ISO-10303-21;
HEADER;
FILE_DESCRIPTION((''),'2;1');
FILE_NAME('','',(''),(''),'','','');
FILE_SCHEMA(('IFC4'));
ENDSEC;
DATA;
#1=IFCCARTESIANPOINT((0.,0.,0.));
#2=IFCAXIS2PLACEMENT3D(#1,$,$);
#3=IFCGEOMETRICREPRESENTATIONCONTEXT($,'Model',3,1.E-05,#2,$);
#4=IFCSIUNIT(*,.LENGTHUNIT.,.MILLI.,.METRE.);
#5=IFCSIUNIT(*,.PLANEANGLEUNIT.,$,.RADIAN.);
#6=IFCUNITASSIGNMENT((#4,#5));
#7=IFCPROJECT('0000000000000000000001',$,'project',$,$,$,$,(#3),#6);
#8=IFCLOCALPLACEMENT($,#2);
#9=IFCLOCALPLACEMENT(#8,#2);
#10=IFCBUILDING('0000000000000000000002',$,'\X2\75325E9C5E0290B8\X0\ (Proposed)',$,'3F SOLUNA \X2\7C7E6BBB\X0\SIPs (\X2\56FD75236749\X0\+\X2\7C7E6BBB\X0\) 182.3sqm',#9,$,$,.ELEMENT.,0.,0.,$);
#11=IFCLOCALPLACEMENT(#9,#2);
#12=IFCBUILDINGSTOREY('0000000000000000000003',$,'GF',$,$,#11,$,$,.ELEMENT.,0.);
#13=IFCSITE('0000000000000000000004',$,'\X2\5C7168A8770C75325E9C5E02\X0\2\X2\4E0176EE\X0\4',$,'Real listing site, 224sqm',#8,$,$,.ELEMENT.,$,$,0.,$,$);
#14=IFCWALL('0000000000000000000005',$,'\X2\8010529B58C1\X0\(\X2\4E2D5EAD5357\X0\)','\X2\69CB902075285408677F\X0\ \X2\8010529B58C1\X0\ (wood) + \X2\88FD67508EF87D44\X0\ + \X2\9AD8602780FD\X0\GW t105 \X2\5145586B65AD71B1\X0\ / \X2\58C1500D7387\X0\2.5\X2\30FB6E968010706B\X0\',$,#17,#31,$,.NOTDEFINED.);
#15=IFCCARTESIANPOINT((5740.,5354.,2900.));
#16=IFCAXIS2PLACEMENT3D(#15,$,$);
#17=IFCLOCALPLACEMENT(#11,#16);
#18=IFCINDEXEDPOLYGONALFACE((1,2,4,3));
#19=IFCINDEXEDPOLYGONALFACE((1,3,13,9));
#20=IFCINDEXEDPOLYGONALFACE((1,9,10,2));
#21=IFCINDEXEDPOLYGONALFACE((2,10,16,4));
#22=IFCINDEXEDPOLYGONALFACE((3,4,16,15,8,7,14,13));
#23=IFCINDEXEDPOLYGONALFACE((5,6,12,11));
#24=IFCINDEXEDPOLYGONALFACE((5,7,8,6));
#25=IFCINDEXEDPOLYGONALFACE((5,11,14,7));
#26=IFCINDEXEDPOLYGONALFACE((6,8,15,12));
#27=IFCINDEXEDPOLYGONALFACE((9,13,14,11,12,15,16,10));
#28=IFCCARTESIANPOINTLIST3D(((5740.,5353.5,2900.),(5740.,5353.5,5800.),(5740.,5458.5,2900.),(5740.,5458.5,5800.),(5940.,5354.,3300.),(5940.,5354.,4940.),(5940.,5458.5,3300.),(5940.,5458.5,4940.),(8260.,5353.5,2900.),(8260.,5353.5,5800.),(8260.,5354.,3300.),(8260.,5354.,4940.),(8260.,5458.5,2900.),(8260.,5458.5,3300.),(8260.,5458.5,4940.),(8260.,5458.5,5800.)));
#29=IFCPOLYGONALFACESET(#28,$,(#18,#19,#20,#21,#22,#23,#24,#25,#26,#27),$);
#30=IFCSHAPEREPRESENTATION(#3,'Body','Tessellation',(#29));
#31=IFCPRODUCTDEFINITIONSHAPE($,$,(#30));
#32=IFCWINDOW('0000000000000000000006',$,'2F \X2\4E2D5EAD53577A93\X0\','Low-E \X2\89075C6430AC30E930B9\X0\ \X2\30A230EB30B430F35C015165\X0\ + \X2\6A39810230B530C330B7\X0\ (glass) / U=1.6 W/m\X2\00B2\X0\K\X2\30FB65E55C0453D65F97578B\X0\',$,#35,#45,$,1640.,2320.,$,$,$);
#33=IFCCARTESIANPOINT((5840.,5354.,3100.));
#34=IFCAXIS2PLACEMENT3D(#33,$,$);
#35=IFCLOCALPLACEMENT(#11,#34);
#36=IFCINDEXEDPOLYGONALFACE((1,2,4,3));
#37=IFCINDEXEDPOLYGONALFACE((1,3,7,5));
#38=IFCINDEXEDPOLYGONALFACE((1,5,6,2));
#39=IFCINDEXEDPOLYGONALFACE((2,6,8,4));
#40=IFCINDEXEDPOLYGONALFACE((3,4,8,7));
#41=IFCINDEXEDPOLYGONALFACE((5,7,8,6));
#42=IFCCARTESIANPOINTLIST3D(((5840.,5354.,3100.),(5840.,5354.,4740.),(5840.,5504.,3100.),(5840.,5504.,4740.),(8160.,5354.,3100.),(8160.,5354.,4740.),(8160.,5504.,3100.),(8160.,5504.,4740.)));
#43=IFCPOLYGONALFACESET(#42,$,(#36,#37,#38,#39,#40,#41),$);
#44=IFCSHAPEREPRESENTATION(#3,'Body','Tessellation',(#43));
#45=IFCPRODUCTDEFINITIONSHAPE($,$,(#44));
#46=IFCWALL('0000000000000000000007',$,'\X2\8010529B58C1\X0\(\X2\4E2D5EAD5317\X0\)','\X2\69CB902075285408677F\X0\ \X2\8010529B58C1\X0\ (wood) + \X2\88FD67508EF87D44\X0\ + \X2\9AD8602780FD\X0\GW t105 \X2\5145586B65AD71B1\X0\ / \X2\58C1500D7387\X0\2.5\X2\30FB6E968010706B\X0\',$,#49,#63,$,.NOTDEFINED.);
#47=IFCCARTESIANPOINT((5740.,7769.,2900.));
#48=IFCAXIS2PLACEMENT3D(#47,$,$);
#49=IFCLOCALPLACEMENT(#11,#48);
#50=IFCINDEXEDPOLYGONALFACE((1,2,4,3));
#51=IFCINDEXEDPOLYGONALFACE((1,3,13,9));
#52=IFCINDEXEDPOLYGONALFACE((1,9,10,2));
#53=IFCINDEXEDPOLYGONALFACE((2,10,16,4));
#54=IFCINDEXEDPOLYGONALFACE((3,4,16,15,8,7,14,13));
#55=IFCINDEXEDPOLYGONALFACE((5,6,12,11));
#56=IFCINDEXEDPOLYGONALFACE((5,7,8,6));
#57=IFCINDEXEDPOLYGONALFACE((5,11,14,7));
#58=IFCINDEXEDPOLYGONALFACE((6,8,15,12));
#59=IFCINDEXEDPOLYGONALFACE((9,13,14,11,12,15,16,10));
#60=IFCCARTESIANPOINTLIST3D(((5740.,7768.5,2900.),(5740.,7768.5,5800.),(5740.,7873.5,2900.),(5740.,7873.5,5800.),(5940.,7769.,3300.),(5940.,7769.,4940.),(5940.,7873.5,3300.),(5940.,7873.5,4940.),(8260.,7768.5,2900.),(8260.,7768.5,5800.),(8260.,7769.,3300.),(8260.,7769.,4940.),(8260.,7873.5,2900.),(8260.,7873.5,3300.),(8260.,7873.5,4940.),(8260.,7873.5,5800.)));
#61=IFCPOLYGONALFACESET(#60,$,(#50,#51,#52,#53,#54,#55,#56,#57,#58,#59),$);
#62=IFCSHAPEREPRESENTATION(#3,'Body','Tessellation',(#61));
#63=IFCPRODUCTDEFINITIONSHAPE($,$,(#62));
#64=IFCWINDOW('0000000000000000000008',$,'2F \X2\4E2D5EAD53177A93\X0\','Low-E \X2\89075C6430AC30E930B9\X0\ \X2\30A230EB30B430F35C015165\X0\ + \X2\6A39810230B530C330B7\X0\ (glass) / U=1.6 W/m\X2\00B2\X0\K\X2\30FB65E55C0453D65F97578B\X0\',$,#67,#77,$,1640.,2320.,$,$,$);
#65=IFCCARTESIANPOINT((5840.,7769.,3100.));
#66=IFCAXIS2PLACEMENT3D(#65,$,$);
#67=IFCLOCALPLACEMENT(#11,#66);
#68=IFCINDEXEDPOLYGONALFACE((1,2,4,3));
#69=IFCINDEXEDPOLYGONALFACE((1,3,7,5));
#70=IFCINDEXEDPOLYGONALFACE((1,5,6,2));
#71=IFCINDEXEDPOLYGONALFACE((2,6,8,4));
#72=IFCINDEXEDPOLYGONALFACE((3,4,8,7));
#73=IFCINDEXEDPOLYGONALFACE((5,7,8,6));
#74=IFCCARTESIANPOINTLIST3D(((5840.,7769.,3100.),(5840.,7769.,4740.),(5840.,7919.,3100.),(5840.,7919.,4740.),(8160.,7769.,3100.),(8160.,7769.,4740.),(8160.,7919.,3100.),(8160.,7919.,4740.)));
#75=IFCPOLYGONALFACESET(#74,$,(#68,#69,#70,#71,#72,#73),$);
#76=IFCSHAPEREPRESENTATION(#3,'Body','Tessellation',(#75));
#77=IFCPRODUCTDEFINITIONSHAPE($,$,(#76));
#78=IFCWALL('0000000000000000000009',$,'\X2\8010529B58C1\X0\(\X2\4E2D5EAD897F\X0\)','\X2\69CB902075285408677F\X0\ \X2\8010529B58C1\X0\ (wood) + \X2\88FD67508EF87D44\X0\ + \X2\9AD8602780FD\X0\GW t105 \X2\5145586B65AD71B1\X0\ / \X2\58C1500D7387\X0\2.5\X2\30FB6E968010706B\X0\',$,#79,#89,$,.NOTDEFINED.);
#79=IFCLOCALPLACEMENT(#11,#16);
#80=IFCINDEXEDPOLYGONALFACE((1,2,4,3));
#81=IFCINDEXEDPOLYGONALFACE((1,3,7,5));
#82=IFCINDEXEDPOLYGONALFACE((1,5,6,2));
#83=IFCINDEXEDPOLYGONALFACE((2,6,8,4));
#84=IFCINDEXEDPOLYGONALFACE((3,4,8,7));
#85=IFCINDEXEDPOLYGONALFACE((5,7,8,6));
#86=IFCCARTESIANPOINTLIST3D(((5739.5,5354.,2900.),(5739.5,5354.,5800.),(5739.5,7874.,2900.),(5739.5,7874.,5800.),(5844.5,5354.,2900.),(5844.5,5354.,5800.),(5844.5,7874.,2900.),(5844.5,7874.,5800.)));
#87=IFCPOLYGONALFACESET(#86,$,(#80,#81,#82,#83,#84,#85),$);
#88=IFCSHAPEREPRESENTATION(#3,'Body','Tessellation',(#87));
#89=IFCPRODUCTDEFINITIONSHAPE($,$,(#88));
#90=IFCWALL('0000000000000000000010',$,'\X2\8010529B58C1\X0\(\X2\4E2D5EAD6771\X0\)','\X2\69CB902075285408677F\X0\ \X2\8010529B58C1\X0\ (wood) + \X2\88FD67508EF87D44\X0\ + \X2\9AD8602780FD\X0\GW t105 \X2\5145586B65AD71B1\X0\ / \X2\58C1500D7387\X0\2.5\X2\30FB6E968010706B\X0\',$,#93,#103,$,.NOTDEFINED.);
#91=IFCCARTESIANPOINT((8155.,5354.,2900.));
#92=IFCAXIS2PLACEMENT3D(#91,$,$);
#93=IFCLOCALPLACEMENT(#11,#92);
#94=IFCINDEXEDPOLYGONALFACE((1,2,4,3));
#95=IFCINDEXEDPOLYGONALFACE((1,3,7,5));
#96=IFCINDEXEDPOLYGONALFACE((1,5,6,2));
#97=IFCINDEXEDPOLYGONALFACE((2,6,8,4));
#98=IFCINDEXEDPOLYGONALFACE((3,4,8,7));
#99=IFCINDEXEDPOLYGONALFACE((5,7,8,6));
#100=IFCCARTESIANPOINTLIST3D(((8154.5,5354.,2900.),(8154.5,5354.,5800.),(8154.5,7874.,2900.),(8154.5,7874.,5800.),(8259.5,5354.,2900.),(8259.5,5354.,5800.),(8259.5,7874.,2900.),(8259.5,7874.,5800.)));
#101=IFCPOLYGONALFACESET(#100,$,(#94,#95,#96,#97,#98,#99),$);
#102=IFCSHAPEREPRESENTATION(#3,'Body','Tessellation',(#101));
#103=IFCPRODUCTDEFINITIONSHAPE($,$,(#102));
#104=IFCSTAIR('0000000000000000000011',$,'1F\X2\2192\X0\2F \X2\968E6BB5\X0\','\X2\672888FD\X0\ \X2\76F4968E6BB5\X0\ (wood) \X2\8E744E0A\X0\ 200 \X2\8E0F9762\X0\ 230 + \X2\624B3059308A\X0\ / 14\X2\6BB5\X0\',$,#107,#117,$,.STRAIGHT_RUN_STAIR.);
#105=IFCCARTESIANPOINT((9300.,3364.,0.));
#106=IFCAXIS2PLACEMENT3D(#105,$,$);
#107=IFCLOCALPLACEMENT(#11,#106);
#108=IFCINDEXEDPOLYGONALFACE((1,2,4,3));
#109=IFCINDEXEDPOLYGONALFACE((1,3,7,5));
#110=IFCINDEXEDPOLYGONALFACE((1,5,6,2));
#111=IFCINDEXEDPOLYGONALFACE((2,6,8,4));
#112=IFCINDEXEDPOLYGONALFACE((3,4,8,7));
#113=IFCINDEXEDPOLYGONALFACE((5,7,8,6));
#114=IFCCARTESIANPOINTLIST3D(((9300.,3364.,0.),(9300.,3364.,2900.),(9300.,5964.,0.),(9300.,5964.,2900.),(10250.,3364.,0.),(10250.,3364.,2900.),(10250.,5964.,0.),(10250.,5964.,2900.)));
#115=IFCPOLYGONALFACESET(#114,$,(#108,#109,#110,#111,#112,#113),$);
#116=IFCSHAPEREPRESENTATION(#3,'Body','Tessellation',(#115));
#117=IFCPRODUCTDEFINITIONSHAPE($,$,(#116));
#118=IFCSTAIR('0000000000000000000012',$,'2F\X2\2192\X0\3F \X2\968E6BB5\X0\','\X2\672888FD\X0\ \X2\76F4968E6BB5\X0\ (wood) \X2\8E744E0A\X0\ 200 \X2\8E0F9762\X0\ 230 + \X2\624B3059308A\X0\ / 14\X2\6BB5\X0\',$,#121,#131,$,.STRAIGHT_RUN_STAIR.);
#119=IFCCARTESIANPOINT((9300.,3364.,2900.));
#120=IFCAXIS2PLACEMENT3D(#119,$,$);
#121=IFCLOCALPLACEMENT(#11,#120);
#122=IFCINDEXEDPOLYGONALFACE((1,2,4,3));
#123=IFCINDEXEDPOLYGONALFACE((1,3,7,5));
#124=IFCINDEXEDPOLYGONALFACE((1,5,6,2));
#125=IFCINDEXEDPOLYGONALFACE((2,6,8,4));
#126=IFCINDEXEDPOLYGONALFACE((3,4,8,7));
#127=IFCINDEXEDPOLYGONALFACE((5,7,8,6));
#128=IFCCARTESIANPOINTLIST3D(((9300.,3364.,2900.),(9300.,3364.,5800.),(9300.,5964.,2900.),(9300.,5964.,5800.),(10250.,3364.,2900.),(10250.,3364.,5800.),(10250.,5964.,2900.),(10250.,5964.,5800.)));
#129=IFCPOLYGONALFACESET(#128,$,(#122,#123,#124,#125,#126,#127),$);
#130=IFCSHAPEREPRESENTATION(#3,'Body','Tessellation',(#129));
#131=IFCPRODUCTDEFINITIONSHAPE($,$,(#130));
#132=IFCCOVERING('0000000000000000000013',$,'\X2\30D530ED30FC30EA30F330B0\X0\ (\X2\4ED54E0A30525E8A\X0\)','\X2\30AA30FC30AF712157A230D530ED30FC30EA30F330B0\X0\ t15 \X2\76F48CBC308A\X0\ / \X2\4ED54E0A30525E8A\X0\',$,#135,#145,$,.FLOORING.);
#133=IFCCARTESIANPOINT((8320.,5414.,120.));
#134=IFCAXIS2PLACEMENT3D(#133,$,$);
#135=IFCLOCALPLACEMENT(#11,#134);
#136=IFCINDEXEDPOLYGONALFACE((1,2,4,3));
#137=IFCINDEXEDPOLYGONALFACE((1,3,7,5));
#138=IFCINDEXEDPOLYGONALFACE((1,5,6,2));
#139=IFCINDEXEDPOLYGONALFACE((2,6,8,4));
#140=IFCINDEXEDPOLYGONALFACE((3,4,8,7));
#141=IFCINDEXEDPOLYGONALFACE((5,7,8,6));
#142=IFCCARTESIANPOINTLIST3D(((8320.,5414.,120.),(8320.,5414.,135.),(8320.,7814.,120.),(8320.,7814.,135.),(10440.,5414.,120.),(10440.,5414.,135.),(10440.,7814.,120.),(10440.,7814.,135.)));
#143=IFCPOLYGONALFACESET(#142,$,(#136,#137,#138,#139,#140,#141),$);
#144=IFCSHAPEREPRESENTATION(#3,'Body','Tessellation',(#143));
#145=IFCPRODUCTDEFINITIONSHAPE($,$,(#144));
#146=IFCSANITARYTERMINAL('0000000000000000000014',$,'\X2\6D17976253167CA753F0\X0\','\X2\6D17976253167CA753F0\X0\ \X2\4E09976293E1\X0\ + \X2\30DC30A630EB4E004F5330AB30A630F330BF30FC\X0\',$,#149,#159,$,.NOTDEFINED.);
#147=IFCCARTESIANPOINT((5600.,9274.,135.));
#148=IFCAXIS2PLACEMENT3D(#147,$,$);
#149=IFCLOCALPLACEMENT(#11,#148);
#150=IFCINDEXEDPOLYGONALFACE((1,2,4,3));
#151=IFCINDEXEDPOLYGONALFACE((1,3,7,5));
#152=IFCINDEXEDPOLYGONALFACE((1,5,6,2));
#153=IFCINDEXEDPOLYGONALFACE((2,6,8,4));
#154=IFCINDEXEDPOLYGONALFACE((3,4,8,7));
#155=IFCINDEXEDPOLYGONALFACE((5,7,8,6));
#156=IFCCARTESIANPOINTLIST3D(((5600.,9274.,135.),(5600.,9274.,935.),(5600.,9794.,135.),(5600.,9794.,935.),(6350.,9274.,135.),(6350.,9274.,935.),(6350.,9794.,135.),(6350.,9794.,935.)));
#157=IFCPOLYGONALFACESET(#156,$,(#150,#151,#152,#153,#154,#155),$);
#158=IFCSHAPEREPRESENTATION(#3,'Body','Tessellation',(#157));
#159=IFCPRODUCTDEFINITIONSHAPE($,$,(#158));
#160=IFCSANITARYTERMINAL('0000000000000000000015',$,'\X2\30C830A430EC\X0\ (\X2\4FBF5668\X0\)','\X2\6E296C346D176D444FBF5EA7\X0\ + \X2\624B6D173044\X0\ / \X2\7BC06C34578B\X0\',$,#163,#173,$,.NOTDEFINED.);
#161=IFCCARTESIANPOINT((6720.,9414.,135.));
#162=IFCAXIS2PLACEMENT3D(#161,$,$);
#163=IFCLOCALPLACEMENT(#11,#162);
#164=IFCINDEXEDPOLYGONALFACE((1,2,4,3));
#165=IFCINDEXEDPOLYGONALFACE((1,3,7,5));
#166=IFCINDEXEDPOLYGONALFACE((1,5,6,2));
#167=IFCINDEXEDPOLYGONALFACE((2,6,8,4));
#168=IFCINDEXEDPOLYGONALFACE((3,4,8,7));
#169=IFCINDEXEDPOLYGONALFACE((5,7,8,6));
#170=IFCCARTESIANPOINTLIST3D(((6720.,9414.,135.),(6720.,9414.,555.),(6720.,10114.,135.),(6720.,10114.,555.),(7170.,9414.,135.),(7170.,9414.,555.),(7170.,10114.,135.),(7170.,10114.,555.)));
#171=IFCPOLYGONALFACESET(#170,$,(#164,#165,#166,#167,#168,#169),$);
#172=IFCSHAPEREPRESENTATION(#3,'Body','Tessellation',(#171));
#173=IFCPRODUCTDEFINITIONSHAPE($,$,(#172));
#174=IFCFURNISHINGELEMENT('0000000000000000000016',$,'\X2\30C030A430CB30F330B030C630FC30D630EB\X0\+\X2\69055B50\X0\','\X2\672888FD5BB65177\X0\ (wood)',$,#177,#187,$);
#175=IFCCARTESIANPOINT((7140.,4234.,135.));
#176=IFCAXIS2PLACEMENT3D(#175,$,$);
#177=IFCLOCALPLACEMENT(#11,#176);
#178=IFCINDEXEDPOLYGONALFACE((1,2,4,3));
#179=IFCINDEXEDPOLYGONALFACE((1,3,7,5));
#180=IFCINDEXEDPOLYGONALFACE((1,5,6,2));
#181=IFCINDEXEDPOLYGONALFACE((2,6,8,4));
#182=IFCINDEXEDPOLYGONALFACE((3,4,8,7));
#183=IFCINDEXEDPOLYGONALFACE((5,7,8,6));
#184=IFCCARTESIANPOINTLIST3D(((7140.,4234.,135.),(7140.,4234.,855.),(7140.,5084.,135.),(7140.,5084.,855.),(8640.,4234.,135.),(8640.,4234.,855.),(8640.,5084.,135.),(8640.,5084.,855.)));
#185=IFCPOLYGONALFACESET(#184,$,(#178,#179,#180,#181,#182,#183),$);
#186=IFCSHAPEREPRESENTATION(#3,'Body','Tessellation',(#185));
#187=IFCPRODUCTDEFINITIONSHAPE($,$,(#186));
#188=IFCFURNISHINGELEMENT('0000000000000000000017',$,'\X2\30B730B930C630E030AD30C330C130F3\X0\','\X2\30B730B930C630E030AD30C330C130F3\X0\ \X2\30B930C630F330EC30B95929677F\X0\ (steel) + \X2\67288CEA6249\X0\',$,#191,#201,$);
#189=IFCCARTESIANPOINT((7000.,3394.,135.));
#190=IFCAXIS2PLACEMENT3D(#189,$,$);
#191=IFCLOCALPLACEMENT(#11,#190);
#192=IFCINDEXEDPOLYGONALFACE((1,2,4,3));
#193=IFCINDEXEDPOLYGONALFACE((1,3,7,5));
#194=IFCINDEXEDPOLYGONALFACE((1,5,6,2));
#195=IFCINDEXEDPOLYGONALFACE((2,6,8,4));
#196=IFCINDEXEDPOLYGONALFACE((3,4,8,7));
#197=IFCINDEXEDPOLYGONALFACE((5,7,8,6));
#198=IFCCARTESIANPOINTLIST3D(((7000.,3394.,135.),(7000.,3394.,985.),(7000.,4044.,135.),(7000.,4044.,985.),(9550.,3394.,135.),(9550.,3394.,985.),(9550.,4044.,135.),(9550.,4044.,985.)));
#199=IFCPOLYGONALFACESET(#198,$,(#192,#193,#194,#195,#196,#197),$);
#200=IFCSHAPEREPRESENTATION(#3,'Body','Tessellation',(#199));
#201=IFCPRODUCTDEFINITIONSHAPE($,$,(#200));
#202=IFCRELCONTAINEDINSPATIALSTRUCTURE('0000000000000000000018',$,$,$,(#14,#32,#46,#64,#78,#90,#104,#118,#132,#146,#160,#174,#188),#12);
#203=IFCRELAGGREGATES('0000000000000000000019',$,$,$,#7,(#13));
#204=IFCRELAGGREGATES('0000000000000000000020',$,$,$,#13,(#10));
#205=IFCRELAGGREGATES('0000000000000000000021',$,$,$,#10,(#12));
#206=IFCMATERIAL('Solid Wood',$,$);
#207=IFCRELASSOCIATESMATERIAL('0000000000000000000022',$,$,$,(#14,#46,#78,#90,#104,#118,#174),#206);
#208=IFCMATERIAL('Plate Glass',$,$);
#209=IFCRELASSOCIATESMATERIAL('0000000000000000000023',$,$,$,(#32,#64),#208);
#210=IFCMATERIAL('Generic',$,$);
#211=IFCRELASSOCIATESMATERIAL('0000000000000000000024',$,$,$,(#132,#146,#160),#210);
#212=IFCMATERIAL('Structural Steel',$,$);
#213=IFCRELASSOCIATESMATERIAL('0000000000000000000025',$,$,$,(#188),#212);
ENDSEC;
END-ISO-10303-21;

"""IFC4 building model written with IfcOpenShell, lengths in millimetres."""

from ifc_helpers import new_model, si_unit, frame, frame_2d, origin, place, context, project, spatial, rectangle, extrude, material, element, fill, save


model = new_model("IFC4")

# Units and contexts
model_context = context("Model", 3, precision=1e-05, world=origin())
ifc_project = project(units=[si_unit("LENGTHUNIT", "METRE", prefix="MILLI"), si_unit("PLANEANGLEUNIT", "RADIAN")], contexts=[model_context])

# Site, building, storey
site_placement = place(None, origin())
site = spatial("IfcSite", under=ifc_project, at=site_placement, Name="山梨県甲府市2丁目4", ObjectType="Real listing site, 224sqm", CompositionType="ELEMENT", RefElevation=0.0)
building_placement = place(site_placement, origin())
building = spatial("IfcBuilding", under=site, at=building_placement, Name="甲府市邸 (Proposed)", ObjectType="3F SOLUNA 籾殻SIPs (国産杉+籾殻) 182.3sqm", CompositionType="ELEMENT", ElevationOfRefHeight=0.0, ElevationOfTerrain=0.0)
storey_placement = place(building_placement, origin())
storey = spatial("IfcBuildingStorey", under=building, at=storey_placement, Name="GF", CompositionType="ELEMENT", Elevation=0.0)

# Shared definitions
ifc_material_1 = material(Name="Solid Wood")

# Shared definitions
ifc_material_2 = material(Name="Plate Glass")

# Walls, openings, windows
wall_1_placement = place(storey_placement, frame((5740.0, 5354.0, 2900.0)))
wall_1 = element("IfcWall", 1, at=wall_1_placement, inside=storey, material=ifc_material_1, Name="耐力壁(中庭南)", Description="構造用合板 耐力壁 (wood) + 製材軸組 + 高性能GW t105 充填断熱 / 壁倍率2.5・準耐火", PredefinedType="NOTDEFINED", context=model_context, shape_type="SweptSolid", body=[
    extrude(rectangle(XDim=2520.0, YDim=105.0, at=frame_2d((1260.0, 52.0))), frame((5740.0, 5354.0, 2900.0)), (0.0, 0.0, 1.0), 2900.0),
])
opening_1_placement = place(storey_placement, frame((5840.0, 5354.0, 3100.0)))
opening_1 = element("IfcOpeningElement", 2, at=opening_1_placement, cuts=wall_1, PredefinedType="NOTDEFINED", context=model_context, shape_type="SweptSolid", body=[
    extrude(rectangle(XDim=2320.0, YDim=150.0, at=frame_2d((1160.0, 75.0))), frame((5840.0, 5354.0, 3100.0)), (0.0, 0.0, 1.0), 1640.0),
])
window_1_placement = place(storey_placement, frame((5840.0, 5354.0, 3100.0)))
window_1 = element("IfcWindow", 3, at=window_1_placement, inside=storey, material=ifc_material_2, Name="2F 中庭南窓", Description="Low-E 複層ガラス アルゴン封入 + 樹脂サッシ (glass) / U=1.6 W/m²K・日射取得型", OverallHeight=1640.0, OverallWidth=2320.0, context=model_context, shape_type="SweptSolid", body=[
    extrude(rectangle(XDim=2320.0, YDim=150.0, at=frame_2d((1160.0, 75.0))), frame((5840.0, 5354.0, 3100.0)), (0.0, 0.0, 1.0), 1640.0),
])
fill(opening_1, window_1)
wall_2_placement = place(storey_placement, frame((5740.0, 7769.0, 2900.0)))
wall_2 = element("IfcWall", 4, at=wall_2_placement, inside=storey, material=ifc_material_1, Name="耐力壁(中庭北)", Description="構造用合板 耐力壁 (wood) + 製材軸組 + 高性能GW t105 充填断熱 / 壁倍率2.5・準耐火", PredefinedType="NOTDEFINED", context=model_context, shape_type="SweptSolid", body=[
    extrude(rectangle(XDim=2520.0, YDim=105.0, at=frame_2d((1260.0, 52.0))), frame((5740.0, 7769.0, 2900.0)), (0.0, 0.0, 1.0), 2900.0),
])
opening_2_placement = place(storey_placement, frame((5840.0, 7769.0, 3100.0)))
opening_2 = element("IfcOpeningElement", 5, at=opening_2_placement, cuts=wall_2, PredefinedType="NOTDEFINED", context=model_context, shape_type="SweptSolid", body=[
    extrude(rectangle(XDim=2320.0, YDim=150.0, at=frame_2d((1160.0, 75.0))), frame((5840.0, 7769.0, 3100.0)), (0.0, 0.0, 1.0), 1640.0),
])
window_2_placement = place(storey_placement, frame((5840.0, 7769.0, 3100.0)))
window_2 = element("IfcWindow", 6, at=window_2_placement, inside=storey, material=ifc_material_2, Name="2F 中庭北窓", Description="Low-E 複層ガラス アルゴン封入 + 樹脂サッシ (glass) / U=1.6 W/m²K・日射取得型", OverallHeight=1640.0, OverallWidth=2320.0, context=model_context, shape_type="SweptSolid", body=[
    extrude(rectangle(XDim=2320.0, YDim=150.0, at=frame_2d((1160.0, 75.0))), frame((5840.0, 7769.0, 3100.0)), (0.0, 0.0, 1.0), 1640.0),
])
fill(opening_2, window_2)

# Walls
wall_3_placement = place(storey_placement, frame((5740.0, 5354.0, 2900.0)))
element("IfcWall", 7, at=wall_3_placement, inside=storey, material=ifc_material_1, Name="耐力壁(中庭西)", Description="構造用合板 耐力壁 (wood) + 製材軸組 + 高性能GW t105 充填断熱 / 壁倍率2.5・準耐火", PredefinedType="NOTDEFINED", context=model_context, shape_type="SweptSolid", body=[
    extrude(rectangle(XDim=105.0, YDim=2520.0, at=frame_2d((52.0, 1260.0))), frame((5740.0, 5354.0, 2900.0)), (0.0, 0.0, 1.0), 2900.0),
])
wall_4_placement = place(storey_placement, frame((8155.0, 5354.0, 2900.0)))
element("IfcWall", 8, at=wall_4_placement, inside=storey, material=ifc_material_1, Name="耐力壁(中庭東)", Description="構造用合板 耐力壁 (wood) + 製材軸組 + 高性能GW t105 充填断熱 / 壁倍率2.5・準耐火", PredefinedType="NOTDEFINED", context=model_context, shape_type="SweptSolid", body=[
    extrude(rectangle(XDim=105.0, YDim=2520.0, at=frame_2d((52.0, 1260.0))), frame((8155.0, 5354.0, 2900.0)), (0.0, 0.0, 1.0), 2900.0),
])

# Stairs
stair_1_placement = place(storey_placement, frame((9300.0, 3364.0, 0.0)))
element("IfcStair", 9, at=stair_1_placement, inside=storey, material=ifc_material_1, Name="1F→2F 階段", Description="木製 直階段 (wood) 蹴上 200 踏面 230 + 手すり / 14段", PredefinedType="STRAIGHT_RUN_STAIR", context=model_context, shape_type="SweptSolid", body=[
    extrude(rectangle(XDim=950.0, YDim=2600.0, at=frame_2d((475.0, 1300.0))), frame((9300.0, 3364.0, 0.0)), (0.0, 0.0, 1.0), 2900.0),
])
stair_2_placement = place(storey_placement, frame((9300.0, 3364.0, 2900.0)))
element("IfcStair", 10, at=stair_2_placement, inside=storey, material=ifc_material_1, Name="2F→3F 階段", Description="木製 直階段 (wood) 蹴上 200 踏面 230 + 手すり / 14段", PredefinedType="STRAIGHT_RUN_STAIR", context=model_context, shape_type="SweptSolid", body=[
    extrude(rectangle(XDim=950.0, YDim=2600.0, at=frame_2d((475.0, 1300.0))), frame((9300.0, 3364.0, 2900.0)), (0.0, 0.0, 1.0), 2900.0),
])

# Covering
ifc_material_3 = material(Name="Generic")
covering_placement = place(storey_placement, frame((8320.0, 5414.0, 120.0)))
element("IfcCovering", 11, at=covering_placement, inside=storey, material=ifc_material_3, Name="フローリング (仕上げ床)", Description="オーク無垢フローリング t15 直貼り / 仕上げ床", PredefinedType="FLOORING", context=model_context, shape_type="SweptSolid", body=[
    extrude(rectangle(XDim=2120.0, YDim=2400.0, at=frame_2d((1060.0, 1200.0))), frame((8320.0, 5414.0, 120.0)), (0.0, 0.0, 1.0), 15.0),
])

# Sanitary terminals
sanitary_terminal_1_placement = place(storey_placement, frame((5600.0, 9274.0, 135.0)))
element("IfcSanitaryTerminal", 12, at=sanitary_terminal_1_placement, inside=storey, material=ifc_material_3, Name="洗面化粧台", Description="洗面化粧台 三面鏡 + ボウル一体カウンター", PredefinedType="NOTDEFINED", context=model_context, shape_type="SweptSolid", body=[
    extrude(rectangle(XDim=750.0, YDim=520.0, at=frame_2d((375.0, 260.0))), frame((5600.0, 9274.0, 135.0)), (0.0, 0.0, 1.0), 800.0),
])
sanitary_terminal_2_placement = place(storey_placement, frame((6720.0, 9414.0, 135.0)))
element("IfcSanitaryTerminal", 13, at=sanitary_terminal_2_placement, inside=storey, material=ifc_material_3, Name="トイレ (便器)", Description="温水洗浄便座 + 手洗い / 節水型", PredefinedType="NOTDEFINED", context=model_context, shape_type="SweptSolid", body=[
    extrude(rectangle(XDim=450.0, YDim=700.0, at=frame_2d((225.0, 350.0))), frame((6720.0, 9414.0, 135.0)), (0.0, 0.0, 1.0), 420.0),
])

# Furnishing elements
furnishing_1_placement = place(storey_placement, frame((7140.0, 4234.0, 135.0)))
element("IfcFurnishingElement", 14, at=furnishing_1_placement, inside=storey, material=ifc_material_1, Name="ダイニングテーブル+椅子", Description="木製家具 (wood)", context=model_context, shape_type="SweptSolid", body=[
    extrude(rectangle(XDim=1500.0, YDim=850.0, at=frame_2d((750.0, 425.0))), frame((7140.0, 4234.0, 135.0)), (0.0, 0.0, 1.0), 720.0),
])
ifc_material_4 = material(Name="Structural Steel")
furnishing_2_placement = place(storey_placement, frame((7000.0, 3394.0, 135.0)))
element("IfcFurnishingElement", 15, at=furnishing_2_placement, inside=storey, material=ifc_material_4, Name="システムキッチン", Description="システムキッチン ステンレス天板 (steel) + 木質扉", context=model_context, shape_type="SweptSolid", body=[
    extrude(rectangle(XDim=2550.0, YDim=650.0, at=frame_2d((1275.0, 325.0))), frame((7000.0, 3394.0, 135.0)), (0.0, 0.0, 1.0), 850.0),
])

save(model, "model.ifc")
